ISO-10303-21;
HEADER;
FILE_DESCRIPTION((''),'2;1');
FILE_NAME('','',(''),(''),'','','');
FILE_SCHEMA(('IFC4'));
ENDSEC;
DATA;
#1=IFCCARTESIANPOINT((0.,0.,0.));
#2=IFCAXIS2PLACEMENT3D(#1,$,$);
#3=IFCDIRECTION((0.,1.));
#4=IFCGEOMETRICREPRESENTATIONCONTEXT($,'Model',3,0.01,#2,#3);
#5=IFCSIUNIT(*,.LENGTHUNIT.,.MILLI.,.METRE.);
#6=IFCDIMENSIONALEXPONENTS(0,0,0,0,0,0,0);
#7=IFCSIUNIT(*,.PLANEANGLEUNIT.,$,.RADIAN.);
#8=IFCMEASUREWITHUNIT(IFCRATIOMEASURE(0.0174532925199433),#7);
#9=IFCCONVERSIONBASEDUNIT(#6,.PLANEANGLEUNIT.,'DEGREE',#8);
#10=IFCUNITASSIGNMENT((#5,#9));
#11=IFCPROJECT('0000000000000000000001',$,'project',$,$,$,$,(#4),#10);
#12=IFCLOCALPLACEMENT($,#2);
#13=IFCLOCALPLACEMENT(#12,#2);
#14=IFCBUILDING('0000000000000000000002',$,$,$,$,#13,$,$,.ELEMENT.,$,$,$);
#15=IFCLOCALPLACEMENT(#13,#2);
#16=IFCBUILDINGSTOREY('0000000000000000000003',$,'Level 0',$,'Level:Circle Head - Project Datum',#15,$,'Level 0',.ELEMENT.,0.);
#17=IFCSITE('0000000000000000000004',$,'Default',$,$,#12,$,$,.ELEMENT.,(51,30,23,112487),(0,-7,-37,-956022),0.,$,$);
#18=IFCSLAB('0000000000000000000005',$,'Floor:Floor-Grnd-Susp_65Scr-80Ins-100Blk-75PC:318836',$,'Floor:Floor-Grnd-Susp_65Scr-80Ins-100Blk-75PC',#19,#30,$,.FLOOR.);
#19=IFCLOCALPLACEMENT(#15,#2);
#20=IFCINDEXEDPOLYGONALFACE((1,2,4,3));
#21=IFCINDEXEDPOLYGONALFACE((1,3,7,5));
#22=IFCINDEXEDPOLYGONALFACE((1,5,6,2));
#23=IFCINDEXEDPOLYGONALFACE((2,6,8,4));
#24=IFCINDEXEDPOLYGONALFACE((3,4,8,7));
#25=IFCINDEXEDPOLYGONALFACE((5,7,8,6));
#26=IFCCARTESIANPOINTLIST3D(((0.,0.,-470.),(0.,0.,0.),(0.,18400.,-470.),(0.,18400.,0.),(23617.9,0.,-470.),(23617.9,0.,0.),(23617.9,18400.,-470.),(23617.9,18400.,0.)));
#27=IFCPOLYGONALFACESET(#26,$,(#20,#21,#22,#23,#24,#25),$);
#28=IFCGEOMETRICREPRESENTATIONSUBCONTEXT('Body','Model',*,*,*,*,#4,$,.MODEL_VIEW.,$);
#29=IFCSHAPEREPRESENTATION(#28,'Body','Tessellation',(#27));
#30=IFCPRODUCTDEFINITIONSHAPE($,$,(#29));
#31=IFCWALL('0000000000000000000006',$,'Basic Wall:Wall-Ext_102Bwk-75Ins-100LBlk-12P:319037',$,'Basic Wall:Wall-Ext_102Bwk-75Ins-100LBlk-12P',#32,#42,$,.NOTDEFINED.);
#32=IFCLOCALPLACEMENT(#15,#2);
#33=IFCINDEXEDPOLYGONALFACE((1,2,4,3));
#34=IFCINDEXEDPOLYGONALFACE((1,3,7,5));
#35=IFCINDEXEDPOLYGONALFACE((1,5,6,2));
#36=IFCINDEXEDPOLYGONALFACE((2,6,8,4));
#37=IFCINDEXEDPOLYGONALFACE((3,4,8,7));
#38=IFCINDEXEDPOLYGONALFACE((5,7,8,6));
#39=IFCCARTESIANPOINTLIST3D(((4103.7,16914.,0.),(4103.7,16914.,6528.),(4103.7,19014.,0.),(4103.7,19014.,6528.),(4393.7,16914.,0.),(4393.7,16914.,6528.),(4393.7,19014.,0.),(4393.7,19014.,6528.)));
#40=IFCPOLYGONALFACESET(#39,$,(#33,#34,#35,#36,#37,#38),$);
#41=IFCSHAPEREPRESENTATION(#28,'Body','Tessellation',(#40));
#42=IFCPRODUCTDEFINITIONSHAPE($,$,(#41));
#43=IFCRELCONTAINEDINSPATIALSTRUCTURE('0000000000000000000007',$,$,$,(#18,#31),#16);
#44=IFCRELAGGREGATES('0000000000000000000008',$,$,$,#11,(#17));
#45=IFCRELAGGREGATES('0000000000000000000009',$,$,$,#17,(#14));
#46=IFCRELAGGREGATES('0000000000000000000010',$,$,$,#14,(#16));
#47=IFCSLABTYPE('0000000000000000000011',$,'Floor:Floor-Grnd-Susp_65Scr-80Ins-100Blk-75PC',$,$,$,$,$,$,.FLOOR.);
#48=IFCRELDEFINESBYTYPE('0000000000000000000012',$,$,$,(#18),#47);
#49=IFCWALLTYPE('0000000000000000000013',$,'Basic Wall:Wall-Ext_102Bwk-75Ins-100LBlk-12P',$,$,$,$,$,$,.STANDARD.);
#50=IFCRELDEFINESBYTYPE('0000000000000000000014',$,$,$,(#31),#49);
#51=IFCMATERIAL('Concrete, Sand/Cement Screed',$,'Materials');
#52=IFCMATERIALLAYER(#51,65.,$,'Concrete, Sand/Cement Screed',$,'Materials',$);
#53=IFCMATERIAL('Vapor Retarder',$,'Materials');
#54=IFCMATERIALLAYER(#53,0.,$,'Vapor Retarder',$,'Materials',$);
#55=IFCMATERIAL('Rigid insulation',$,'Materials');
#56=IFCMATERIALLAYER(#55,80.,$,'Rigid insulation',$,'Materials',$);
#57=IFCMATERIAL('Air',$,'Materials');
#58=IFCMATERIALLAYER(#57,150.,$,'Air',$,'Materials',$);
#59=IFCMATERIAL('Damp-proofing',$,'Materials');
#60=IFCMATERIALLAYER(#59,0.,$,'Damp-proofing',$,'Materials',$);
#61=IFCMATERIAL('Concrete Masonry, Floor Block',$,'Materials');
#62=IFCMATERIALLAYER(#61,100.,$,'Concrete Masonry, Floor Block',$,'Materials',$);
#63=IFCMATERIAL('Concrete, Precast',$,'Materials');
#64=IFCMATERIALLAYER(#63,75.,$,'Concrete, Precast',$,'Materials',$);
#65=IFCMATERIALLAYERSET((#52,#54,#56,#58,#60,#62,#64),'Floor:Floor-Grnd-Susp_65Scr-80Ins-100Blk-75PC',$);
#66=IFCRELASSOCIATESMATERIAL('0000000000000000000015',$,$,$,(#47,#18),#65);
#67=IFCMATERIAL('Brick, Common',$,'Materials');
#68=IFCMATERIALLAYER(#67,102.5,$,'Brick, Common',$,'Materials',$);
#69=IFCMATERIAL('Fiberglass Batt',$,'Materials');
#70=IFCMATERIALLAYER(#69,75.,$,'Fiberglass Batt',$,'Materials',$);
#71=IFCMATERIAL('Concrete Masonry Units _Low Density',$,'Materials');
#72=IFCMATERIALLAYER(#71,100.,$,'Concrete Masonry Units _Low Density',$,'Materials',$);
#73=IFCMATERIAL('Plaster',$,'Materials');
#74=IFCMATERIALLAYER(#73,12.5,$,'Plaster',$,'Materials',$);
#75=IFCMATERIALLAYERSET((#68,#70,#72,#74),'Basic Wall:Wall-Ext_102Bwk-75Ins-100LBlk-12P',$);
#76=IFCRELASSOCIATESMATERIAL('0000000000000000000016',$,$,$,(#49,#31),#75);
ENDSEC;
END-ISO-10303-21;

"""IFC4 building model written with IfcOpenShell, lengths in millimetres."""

from ifc_helpers import new_model, entity, si_unit, converted_unit, direction, frame, frame_2d, origin, origin_2d_with_axis, place, context, subcontext, project, spatial, rectangle, extrude, material, layer, layer_set, layer_usage, type_object, element, save


model = new_model("IFC4")

# Units and contexts
model_context = context("Model", 3, precision=0.01, world=origin(), true_north=direction((0.0, 1.0)))
body_context = subcontext(model_context, "Body", "Model", "MODEL_VIEW")
ifc_project = project(units=[si_unit("LENGTHUNIT", "METRE", prefix="MILLI"), converted_unit("PLANEANGLEUNIT", "DEGREE", entity("IfcRatioMeasure", 0.0174532925199433), si_unit("PLANEANGLEUNIT", "RADIAN"), dimensions=[0, 0, 0, 0, 0, 0, 0])], contexts=[model_context])

# Site, building, storey
site_placement = place(None, origin())
site = spatial("IfcSite", under=ifc_project, at=site_placement, Name="Default", CompositionType="ELEMENT", RefLatitude=(51, 30, 23, 112487), RefLongitude=(0, -7, -37, -956022), RefElevation=0.0)
building_placement = place(site_placement, origin())
building = spatial("IfcBuilding", under=site, at=building_placement, CompositionType="ELEMENT")
storey_placement = place(building_placement, origin())
storey = spatial("IfcBuildingStorey", under=building, at=storey_placement, Name="Level 0", ObjectType="Level:Circle Head - Project Datum", LongName="Level 0", CompositionType="ELEMENT", Elevation=0.0)

# Slab
ifc_material_1 = material(Name="Concrete, Sand/Cement Screed", Category="Materials")
ifc_layer_1 = layer(ifc_material_1, 65.0, Name="Concrete, Sand/Cement Screed", Category="Materials")
ifc_material_2 = material(Name="Vapor Retarder", Category="Materials")
ifc_layer_2 = layer(ifc_material_2, 0.0, Name="Vapor Retarder", Category="Materials")
ifc_material_3 = material(Name="Rigid insulation", Category="Materials")
ifc_layer_3 = layer(ifc_material_3, 80.0, Name="Rigid insulation", Category="Materials")
ifc_material_4 = material(Name="Air", Category="Materials")
ifc_layer_4 = layer(ifc_material_4, 150.0, Name="Air", Category="Materials")
ifc_material_5 = material(Name="Damp-proofing", Category="Materials")
ifc_layer_5 = layer(ifc_material_5, 0.0, Name="Damp-proofing", Category="Materials")
ifc_material_6 = material(Name="Concrete Masonry, Floor Block", Category="Materials")
ifc_layer_6 = layer(ifc_material_6, 100.0, Name="Concrete Masonry, Floor Block", Category="Materials")
ifc_material_7 = material(Name="Concrete, Precast", Category="Materials")
ifc_layer_7 = layer(ifc_material_7, 75.0, Name="Concrete, Precast", Category="Materials")
ifc_layer_set_1 = layer_set([ifc_layer_1, ifc_layer_2, ifc_layer_3, ifc_layer_4, ifc_layer_5, ifc_layer_6, ifc_layer_7], Name="Floor:Floor-Grnd-Susp_65Scr-80Ins-100Blk-75PC")
ifc_layer_usage_1 = layer_usage(ifc_layer_set_1, "AXIS3", "POSITIVE", 0.0)
slab_type_1 = type_object("IfcSlabType", Name="Floor:Floor-Grnd-Susp_65Scr-80Ins-100Blk-75PC", PredefinedType="FLOOR", material=ifc_layer_set_1)
slab_1_placement = place(storey_placement, origin())
element("IfcSlab", 1, at=slab_1_placement, inside=storey, type_object=slab_type_1, material=ifc_layer_usage_1, Name="Floor:Floor-Grnd-Susp_65Scr-80Ins-100Blk-75PC:318836", ObjectType="Floor:Floor-Grnd-Susp_65Scr-80Ins-100Blk-75PC", PredefinedType="FLOOR", context=body_context, shape_type="SweptSolid", body=[
    extrude(rectangle(XDim=18400.0, YDim=23617.9, at=origin_2d_with_axis()), frame((11809.0, 9200.0, 0.0), z_axis=(0.0, 0.0, -1.0), x_axis=(0.0, 1.0, 0.0)), (0.0, 0.0, 1.0), 470.0),
])

# Wall
ifc_material_8 = material(Name="Brick, Common", Category="Materials")
ifc_layer_8 = layer(ifc_material_8, 102.5, Name="Brick, Common", Category="Materials")
ifc_material_9 = material(Name="Fiberglass Batt", Category="Materials")
ifc_layer_9 = layer(ifc_material_9, 75.0, Name="Fiberglass Batt", Category="Materials")
ifc_material_10 = material(Name="Concrete Masonry Units _Low Density", Category="Materials")
ifc_layer_10 = layer(ifc_material_10, 100.0, Name="Concrete Masonry Units _Low Density", Category="Materials")
ifc_material_11 = material(Name="Plaster", Category="Materials")
ifc_layer_11 = layer(ifc_material_11, 12.5, Name="Plaster", Category="Materials")
ifc_layer_set_2 = layer_set([ifc_layer_8, ifc_layer_9, ifc_layer_10, ifc_layer_11], Name="Basic Wall:Wall-Ext_102Bwk-75Ins-100LBlk-12P")
ifc_layer_usage_2 = layer_usage(ifc_layer_set_2, "AXIS2", "NEGATIVE", 145.0)
wall_type = type_object("IfcWallType", Name="Basic Wall:Wall-Ext_102Bwk-75Ins-100LBlk-12P", PredefinedType="STANDARD", material=ifc_layer_set_2)
wall_placement = place(storey_placement, frame((4248.7, 19014.0, 0.0), z_axis=(0.0, 0.0, 1.0), x_axis=(0.0, -1.0, 0.0)))
element("IfcWall", 2, at=wall_placement, inside=storey, type_object=wall_type, material=ifc_layer_usage_2, Name="Basic Wall:Wall-Ext_102Bwk-75Ins-100LBlk-12P:319037", ObjectType="Basic Wall:Wall-Ext_102Bwk-75Ins-100LBlk-12P", PredefinedType="NOTDEFINED", context=body_context, shape_type="SweptSolid", body=[
    extrude(rectangle(XDim=2100.0, YDim=290.0, at=frame_2d((1050.0, 0.0), x_axis=(-1.0, 0.0))), origin(), (0.0, 0.0, 1.0), 6528.0),
])

save(model, "model.ifc")
